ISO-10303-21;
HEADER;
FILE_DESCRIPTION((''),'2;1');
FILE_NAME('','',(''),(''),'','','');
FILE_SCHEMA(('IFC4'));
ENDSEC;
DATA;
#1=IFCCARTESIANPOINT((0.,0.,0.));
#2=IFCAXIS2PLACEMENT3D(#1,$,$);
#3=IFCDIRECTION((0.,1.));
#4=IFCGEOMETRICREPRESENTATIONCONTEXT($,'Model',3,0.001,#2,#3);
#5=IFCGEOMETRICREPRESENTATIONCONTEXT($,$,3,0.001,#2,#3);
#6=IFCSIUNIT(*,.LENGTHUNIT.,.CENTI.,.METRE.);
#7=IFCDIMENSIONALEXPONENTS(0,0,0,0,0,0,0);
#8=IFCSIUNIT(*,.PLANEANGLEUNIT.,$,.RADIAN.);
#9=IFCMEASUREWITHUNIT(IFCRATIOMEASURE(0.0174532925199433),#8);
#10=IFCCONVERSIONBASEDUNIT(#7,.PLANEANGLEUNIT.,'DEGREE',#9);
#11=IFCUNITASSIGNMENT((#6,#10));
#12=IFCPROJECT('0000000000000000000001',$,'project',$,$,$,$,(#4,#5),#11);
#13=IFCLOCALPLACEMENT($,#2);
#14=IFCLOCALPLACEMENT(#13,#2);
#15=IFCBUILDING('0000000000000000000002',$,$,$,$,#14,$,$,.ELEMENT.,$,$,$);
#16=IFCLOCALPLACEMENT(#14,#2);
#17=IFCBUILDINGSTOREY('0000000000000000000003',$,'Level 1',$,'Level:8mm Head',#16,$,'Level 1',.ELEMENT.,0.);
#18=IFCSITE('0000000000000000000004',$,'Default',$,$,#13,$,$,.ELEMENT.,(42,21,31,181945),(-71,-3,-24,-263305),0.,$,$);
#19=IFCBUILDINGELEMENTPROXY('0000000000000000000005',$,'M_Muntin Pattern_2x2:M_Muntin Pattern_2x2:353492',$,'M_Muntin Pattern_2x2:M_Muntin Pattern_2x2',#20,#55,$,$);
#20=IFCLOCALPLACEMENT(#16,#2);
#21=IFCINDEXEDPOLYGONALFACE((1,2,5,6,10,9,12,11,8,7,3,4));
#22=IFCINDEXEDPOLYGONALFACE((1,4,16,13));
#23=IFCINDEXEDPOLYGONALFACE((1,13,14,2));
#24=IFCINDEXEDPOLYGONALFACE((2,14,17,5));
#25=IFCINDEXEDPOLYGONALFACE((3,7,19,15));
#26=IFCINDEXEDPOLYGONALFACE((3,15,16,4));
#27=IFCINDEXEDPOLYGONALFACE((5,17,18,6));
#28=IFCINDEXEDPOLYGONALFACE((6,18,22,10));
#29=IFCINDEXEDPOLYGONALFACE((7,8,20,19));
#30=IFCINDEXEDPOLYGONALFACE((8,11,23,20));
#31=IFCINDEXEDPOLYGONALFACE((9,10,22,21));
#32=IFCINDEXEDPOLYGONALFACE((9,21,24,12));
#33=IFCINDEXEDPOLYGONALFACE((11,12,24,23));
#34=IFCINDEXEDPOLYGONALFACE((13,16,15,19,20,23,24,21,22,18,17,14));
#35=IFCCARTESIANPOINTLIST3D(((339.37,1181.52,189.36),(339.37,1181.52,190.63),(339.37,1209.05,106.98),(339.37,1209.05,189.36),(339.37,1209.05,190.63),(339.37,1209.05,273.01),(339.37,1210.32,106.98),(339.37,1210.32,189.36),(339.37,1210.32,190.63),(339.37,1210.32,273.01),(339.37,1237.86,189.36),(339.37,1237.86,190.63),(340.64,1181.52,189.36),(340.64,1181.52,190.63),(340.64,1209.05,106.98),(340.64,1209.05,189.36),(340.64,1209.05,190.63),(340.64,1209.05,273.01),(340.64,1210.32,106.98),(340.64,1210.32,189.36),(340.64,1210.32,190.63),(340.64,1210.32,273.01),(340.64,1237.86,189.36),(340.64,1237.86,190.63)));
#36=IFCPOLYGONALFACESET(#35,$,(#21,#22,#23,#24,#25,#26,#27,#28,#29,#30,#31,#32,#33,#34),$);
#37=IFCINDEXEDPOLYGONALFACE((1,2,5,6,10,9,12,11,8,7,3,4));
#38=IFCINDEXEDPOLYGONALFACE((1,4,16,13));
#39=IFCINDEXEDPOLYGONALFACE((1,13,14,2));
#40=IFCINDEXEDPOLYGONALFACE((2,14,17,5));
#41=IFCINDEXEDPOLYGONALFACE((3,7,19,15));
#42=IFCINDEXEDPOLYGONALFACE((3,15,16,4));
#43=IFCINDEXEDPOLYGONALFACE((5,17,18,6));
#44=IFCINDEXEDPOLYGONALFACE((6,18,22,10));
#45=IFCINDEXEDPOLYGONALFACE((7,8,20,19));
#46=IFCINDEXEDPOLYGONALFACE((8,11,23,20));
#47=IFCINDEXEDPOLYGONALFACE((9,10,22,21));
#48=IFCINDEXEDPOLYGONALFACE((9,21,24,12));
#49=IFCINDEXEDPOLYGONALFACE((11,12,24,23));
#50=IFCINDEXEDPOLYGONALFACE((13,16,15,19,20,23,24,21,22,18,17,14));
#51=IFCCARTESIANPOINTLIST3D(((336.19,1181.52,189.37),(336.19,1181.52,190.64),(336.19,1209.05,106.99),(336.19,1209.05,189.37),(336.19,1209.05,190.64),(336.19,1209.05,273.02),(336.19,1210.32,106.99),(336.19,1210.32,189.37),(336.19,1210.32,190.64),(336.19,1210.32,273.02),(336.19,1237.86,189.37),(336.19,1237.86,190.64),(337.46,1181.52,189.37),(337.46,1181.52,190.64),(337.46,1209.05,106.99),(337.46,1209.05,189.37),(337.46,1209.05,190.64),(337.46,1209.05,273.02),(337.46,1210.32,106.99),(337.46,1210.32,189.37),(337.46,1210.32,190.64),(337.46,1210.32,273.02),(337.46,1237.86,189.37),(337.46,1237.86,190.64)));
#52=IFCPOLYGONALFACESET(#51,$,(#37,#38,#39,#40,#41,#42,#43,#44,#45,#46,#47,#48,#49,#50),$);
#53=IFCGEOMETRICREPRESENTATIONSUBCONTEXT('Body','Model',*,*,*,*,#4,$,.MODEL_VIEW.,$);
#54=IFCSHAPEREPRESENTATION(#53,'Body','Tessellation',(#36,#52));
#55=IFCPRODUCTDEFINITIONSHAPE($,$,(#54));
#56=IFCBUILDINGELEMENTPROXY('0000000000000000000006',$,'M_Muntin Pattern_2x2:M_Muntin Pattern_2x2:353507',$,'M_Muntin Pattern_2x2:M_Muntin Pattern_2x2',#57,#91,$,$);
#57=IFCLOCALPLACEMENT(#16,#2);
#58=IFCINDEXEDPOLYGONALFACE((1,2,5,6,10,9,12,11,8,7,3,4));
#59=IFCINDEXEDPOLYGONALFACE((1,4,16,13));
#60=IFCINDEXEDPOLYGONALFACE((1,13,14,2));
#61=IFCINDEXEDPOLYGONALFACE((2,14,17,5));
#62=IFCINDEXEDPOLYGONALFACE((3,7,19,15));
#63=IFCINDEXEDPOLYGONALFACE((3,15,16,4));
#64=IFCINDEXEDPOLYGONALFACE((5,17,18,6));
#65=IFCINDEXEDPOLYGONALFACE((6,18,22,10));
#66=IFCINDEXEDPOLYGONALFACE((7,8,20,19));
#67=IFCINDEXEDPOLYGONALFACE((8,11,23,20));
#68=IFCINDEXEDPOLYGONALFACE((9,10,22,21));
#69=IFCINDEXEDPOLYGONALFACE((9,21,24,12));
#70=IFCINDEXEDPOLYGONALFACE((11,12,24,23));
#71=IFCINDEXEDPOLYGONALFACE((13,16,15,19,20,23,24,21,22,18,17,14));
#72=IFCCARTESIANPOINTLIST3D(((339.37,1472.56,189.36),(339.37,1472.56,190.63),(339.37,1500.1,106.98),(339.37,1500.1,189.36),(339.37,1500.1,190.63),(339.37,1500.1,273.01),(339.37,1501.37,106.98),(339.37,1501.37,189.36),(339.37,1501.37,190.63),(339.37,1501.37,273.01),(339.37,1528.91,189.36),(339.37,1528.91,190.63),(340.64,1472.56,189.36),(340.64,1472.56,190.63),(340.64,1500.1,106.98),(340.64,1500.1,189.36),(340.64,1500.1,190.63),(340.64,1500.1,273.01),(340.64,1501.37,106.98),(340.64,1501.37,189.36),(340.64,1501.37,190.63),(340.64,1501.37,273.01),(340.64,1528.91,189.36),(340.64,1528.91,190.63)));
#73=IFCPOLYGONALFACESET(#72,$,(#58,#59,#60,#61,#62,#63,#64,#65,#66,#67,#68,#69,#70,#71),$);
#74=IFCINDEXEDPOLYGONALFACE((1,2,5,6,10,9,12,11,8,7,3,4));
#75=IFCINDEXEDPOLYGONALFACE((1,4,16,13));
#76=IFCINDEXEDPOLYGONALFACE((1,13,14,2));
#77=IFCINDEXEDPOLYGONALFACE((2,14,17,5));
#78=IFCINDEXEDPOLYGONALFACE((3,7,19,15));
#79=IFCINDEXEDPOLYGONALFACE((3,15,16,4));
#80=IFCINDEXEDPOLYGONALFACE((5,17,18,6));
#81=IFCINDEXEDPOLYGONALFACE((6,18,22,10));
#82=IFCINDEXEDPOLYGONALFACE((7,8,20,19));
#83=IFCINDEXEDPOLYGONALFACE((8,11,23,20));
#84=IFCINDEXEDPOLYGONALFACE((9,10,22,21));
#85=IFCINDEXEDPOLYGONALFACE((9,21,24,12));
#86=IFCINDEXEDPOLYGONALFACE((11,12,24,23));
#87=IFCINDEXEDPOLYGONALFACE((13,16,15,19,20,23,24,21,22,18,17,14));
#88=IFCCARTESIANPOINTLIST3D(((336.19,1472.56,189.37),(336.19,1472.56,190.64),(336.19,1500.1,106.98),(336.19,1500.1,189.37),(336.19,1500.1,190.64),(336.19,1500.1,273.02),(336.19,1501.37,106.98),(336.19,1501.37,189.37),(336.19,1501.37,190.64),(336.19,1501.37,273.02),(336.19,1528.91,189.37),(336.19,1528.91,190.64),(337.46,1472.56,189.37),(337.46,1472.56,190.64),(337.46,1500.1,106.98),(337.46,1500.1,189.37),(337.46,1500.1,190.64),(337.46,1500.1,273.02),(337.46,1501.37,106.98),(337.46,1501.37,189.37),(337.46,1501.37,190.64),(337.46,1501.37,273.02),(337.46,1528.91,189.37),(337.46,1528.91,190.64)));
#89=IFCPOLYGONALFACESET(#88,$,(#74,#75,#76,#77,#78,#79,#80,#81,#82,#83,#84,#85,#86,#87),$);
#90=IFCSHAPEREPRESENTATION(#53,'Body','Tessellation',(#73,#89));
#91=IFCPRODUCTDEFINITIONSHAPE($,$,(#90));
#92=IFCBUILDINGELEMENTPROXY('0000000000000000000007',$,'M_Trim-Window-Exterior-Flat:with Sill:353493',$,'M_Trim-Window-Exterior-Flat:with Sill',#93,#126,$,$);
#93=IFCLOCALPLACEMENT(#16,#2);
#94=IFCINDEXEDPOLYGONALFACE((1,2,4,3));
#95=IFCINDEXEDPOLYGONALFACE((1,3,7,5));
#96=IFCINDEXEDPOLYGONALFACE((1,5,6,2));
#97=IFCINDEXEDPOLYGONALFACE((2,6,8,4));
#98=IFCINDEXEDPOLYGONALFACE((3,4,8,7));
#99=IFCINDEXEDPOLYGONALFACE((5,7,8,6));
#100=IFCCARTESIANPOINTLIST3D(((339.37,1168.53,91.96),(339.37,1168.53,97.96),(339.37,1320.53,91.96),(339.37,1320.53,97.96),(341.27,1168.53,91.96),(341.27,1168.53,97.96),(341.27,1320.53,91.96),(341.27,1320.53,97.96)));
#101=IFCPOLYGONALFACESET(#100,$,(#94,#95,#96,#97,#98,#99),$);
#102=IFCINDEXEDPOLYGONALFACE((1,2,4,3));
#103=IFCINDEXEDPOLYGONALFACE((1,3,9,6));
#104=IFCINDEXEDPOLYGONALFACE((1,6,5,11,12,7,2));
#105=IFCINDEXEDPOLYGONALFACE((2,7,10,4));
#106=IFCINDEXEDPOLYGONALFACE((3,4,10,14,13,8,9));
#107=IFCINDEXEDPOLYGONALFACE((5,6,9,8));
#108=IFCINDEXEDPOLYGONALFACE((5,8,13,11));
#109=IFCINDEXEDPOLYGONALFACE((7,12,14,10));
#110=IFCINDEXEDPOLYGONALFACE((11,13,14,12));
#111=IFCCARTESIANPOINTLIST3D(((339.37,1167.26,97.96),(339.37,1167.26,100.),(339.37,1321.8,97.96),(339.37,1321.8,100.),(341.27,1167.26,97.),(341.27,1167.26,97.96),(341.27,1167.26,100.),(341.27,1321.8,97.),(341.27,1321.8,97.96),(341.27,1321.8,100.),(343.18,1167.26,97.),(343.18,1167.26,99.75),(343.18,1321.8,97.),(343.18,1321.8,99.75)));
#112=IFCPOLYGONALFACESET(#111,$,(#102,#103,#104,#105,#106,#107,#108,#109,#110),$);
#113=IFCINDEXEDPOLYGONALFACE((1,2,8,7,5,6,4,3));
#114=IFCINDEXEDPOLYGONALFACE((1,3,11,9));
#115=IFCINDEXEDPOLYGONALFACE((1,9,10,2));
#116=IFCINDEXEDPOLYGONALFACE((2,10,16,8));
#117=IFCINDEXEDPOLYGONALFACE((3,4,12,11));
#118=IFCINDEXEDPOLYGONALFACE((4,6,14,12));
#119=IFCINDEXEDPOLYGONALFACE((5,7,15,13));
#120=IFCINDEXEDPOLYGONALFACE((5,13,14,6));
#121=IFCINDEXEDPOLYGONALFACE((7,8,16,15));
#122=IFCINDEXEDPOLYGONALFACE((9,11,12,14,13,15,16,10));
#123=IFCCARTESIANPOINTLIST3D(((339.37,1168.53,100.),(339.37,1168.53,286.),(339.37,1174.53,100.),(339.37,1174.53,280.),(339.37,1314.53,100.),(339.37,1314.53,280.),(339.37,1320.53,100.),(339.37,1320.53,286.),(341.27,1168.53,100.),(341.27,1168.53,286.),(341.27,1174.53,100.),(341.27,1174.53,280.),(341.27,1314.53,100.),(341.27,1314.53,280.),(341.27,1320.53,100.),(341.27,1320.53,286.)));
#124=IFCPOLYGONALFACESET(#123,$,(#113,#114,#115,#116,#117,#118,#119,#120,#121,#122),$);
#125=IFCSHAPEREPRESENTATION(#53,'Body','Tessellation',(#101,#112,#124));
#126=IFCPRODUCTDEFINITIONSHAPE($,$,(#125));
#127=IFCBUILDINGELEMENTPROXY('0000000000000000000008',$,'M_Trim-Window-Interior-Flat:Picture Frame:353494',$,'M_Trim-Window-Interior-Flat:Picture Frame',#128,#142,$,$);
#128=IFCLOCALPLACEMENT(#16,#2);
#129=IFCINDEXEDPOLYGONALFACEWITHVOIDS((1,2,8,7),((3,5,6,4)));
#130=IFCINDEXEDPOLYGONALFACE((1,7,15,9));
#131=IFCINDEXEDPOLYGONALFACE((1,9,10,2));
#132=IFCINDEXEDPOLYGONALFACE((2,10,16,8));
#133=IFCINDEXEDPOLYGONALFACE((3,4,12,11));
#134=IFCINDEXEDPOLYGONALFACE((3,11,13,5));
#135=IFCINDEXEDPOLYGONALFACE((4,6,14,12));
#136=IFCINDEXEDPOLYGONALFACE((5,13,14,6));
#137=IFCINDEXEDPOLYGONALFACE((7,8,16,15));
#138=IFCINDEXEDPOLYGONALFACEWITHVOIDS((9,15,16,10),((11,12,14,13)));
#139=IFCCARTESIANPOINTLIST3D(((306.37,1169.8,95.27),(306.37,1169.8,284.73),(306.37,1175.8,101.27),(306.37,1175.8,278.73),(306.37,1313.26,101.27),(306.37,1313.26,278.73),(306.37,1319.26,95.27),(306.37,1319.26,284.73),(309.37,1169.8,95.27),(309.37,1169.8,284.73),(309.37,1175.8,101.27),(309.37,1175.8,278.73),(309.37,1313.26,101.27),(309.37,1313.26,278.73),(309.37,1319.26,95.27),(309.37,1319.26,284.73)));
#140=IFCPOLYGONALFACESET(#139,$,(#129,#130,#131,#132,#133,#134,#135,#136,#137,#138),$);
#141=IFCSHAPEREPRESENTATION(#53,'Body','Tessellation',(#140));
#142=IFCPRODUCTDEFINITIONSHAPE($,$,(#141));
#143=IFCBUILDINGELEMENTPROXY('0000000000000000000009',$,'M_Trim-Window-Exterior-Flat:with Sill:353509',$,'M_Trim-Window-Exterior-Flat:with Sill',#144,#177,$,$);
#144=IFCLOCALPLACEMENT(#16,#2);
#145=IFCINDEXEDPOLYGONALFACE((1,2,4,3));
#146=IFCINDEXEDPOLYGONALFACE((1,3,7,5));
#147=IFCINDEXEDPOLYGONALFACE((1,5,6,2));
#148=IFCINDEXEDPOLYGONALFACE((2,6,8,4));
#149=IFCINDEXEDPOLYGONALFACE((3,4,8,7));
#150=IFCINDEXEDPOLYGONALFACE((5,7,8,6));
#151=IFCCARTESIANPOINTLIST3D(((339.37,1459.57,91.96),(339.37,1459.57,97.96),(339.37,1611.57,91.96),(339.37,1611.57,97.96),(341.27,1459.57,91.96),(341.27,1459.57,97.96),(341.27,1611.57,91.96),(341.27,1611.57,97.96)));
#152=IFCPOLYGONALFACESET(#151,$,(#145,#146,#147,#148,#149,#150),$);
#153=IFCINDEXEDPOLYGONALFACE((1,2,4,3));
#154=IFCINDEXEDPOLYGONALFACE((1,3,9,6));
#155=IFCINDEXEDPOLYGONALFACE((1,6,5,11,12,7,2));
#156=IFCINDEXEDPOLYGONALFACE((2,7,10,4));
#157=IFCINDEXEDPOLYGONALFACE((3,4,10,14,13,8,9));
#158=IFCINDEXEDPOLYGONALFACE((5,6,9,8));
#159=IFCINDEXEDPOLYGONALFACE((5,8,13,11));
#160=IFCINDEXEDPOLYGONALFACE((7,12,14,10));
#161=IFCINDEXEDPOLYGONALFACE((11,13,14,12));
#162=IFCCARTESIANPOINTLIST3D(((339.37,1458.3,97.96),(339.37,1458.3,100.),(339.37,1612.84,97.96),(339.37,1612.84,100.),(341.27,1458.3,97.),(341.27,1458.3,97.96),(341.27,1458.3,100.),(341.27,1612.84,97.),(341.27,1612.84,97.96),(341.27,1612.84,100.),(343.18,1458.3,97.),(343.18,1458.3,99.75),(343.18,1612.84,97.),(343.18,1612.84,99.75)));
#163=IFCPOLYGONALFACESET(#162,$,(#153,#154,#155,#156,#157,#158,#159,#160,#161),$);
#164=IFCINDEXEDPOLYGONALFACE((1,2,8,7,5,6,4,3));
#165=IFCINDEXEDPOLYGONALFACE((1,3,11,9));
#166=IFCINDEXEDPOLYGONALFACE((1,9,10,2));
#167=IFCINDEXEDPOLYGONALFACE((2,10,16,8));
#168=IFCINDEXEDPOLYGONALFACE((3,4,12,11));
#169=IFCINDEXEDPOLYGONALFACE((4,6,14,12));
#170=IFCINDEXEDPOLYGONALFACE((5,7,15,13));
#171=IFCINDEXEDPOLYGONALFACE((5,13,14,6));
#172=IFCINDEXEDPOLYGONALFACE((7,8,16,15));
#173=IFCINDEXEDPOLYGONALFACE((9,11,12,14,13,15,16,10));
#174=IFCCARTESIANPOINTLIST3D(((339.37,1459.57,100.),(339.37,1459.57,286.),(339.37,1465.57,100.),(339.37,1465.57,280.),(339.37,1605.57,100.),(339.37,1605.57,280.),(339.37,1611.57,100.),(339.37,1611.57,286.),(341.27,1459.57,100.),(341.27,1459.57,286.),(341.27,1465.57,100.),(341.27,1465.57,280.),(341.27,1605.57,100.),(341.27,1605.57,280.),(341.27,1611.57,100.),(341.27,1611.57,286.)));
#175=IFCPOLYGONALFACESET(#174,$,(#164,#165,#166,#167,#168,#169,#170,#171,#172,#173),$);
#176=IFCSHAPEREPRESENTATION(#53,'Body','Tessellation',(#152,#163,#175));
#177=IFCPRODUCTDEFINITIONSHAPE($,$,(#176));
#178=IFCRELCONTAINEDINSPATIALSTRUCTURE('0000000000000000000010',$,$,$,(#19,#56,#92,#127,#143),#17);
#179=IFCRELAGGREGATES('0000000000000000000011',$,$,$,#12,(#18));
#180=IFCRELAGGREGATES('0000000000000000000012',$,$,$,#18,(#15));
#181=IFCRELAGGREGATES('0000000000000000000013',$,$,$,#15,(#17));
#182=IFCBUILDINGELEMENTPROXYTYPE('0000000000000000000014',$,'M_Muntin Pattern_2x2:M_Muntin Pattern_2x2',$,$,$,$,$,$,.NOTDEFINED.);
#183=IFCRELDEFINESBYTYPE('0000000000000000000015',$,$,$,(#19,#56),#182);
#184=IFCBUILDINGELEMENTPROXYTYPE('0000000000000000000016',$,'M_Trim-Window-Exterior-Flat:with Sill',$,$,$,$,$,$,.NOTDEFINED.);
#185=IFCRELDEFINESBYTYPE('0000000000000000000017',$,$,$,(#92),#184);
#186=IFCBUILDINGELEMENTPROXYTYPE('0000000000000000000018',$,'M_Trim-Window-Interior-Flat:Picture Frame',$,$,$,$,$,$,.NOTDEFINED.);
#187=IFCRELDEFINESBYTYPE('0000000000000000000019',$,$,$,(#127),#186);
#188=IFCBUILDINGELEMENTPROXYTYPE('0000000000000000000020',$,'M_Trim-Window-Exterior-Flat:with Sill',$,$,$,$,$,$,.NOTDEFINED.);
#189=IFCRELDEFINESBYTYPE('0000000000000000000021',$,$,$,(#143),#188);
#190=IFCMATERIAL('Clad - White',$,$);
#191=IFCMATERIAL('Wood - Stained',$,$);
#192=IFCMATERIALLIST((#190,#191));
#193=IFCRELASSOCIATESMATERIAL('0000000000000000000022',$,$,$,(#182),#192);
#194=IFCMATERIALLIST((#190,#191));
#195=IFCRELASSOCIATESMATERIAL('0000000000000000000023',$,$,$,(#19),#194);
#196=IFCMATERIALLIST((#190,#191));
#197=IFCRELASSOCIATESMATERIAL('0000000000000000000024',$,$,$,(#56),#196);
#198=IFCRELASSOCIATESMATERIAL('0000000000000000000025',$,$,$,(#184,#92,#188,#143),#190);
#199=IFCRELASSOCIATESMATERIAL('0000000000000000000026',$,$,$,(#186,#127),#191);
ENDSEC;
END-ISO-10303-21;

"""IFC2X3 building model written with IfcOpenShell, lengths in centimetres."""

from ifc_helpers import new_model, entity, si_unit, converted_unit, direction, frame, frame_2d, origin, place, context, subcontext, project, spatial, polyline, rectangle, outline, extrude, source, transform, mapped, material, material_list, type_object, type_shapes, element, save


model = new_model("IFC2X3")

# Units and contexts
model_context = context("Model", 3, precision=0.001, world=origin(), true_north=direction((0.0, 1.0)))
context_of_model = context(None, 3, precision=0.001, world=origin(), true_north=direction((0.0, 1.0)))
body_context = subcontext(model_context, "Body", "Model", "MODEL_VIEW")
ifc_project = project(units=[si_unit("LENGTHUNIT", "METRE", prefix="CENTI"), converted_unit("PLANEANGLEUNIT", "DEGREE", entity("IfcRatioMeasure", 0.0174532925199433), si_unit("PLANEANGLEUNIT", "RADIAN"), dimensions=[0, 0, 0, 0, 0, 0, 0])], contexts=[model_context, context_of_model])

# Site, building, storey
site_placement = place(None, origin())
site = spatial("IfcSite", under=ifc_project, at=site_placement, Name="Default", CompositionType="ELEMENT", RefLatitude=(42, 21, 31, 181945), RefLongitude=(-71, -3, -24, -263305), RefElevation=0.0)
building_placement = place(site_placement, origin())
building = spatial("IfcBuilding", under=site, at=building_placement, CompositionType="ELEMENT")
storey_placement = place(building_placement, origin())
storey = spatial("IfcBuildingStorey", under=building, at=storey_placement, Name="Level 1", ObjectType="Level:8mm Head", LongName="Level 1", CompositionType="ELEMENT", Elevation=0.0)

# Building element proxies
ifc_material_1 = material(Name="Clad - White")
ifc_material_2 = material(Name="Wood - Stained")
ifc_material_list_1 = material_list([ifc_material_1, ifc_material_2])
ifc_material_list_2 = material_list([ifc_material_1, ifc_material_2])
building_element_proxy_type_1 = type_object("IfcBuildingElementProxyType", Name="M_Muntin Pattern_2x2:M_Muntin Pattern_2x2", PredefinedType="NOTDEFINED", material=ifc_material_list_2)
shared_shape_1 = source(origin(), body_context, "Body", "SweptSolid", [
    extrude(outline(polyline([(0.64, -0.64), (83.01, -0.64), (83.01, 0.63), (0.64, 0.63), (0.64, 28.17), (-0.63, 28.17), (-0.63, 0.63), (-83.02, 0.63), (-83.02, -0.64), (-0.63, -0.64), (-0.63, -28.17), (0.64, -28.17), (0.64, -0.64)])), frame((0.0, -2.22, 83.01), z_axis=(0.0, 1.0, 0.0), x_axis=(0.0, 0.0, 1.0)), (0.0, 0.0, 1.0), 1.27),
    extrude(outline(polyline([(0.64, -0.64), (83.02, -0.64), (83.02, 0.63), (0.64, 0.63), (0.64, 28.17), (-0.63, 28.17), (-0.63, 0.63), (-83.02, 0.63), (-83.02, -0.64), (-0.63, -0.64), (-0.63, -28.17), (0.64, -28.17), (0.64, -0.64)])), frame((0.0, 0.95, 83.02), z_axis=(0.0, 1.0, 0.0), x_axis=(0.0, 0.0, 1.0)), (0.0, 0.0, 1.0), 1.27),
])
type_shapes(building_element_proxy_type_1, [shared_shape_1])
proxy_1_placement = place(storey_placement, frame((338.41, 1209.69, 106.99), z_axis=(0.0, 0.0, 1.0), x_axis=(0.0, 1.0, 0.0)))
element("IfcBuildingElementProxy", 1, at=proxy_1_placement, inside=storey, type_object=building_element_proxy_type_1, material=ifc_material_list_1, Name="M_Muntin Pattern_2x2:M_Muntin Pattern_2x2:353492", ObjectType="M_Muntin Pattern_2x2:M_Muntin Pattern_2x2", context=body_context, shape_type="MappedRepresentation", body=[
    mapped(shared_shape_1, transform((0.0, 0.0, 0.0), scale=1.0)),
])
ifc_material_list_3 = material_list([ifc_material_1, ifc_material_2])
proxy_2_placement = place(storey_placement, frame((338.41, 1500.73, 106.98), z_axis=(0.0, 0.0, 1.0), x_axis=(0.0, 1.0, 0.0)))
element("IfcBuildingElementProxy", 2, at=proxy_2_placement, inside=storey, type_object=building_element_proxy_type_1, material=ifc_material_list_3, Name="M_Muntin Pattern_2x2:M_Muntin Pattern_2x2:353507", ObjectType="M_Muntin Pattern_2x2:M_Muntin Pattern_2x2", context=body_context, shape_type="MappedRepresentation", body=[
    mapped(shared_shape_1, transform((0.0, 0.0, 0.0), scale=1.0)),
])
building_element_proxy_type_2 = type_object("IfcBuildingElementProxyType", Name="M_Trim-Window-Exterior-Flat:with Sill", PredefinedType="NOTDEFINED", material=ifc_material_1)
shared_shape_2 = source(origin(), body_context, "Body", "SweptSolid", [
    extrude(rectangle(XDim=152.0, YDim=6.0, at=frame_2d((0.0, 0.0), x_axis=(1.0, 0.0))), frame((0.0, -185.04, 0.0), z_axis=(0.0, 0.0, 1.0), x_axis=(-1.0, 0.0, 0.0)), (0.0, 0.0, 1.0), 1.91),
    extrude(outline(polyline([(-1.9, -1.52), (0.0, -1.52), (0.0, -0.57), (1.9, -0.57), (1.9, 1.48), (0.0, 1.48), (-1.9, 1.23), (-1.9, -1.52)])), frame((-77.27, -181.48, 1.9), z_axis=(1.0, 0.0, 0.0), x_axis=(0.0, 0.0, -1.0)), (0.0, 0.0, 1.0), 154.54),
    extrude(outline(polyline([(-94.5, -76.0), (91.5, -76.0), (91.5, -70.0), (-88.5, -70.0), (-88.5, 70.0), (91.5, 70.0), (91.5, 76.0), (-94.5, 76.0), (-94.5, -76.0)])), frame((0.0, -88.5, 0.0), z_axis=(0.0, 0.0, 1.0), x_axis=(0.0, -1.0, 0.0)), (0.0, 0.0, 1.0), 1.91),
])
type_shapes(building_element_proxy_type_2, [shared_shape_2])
proxy_3_placement = place(storey_placement, frame((339.37, 1244.53, 280.0), z_axis=(1.0, 0.0, 0.0), x_axis=(0.0, 1.0, 0.0)))
element("IfcBuildingElementProxy", 3, at=proxy_3_placement, inside=storey, type_object=building_element_proxy_type_2, material=ifc_material_1, Name="M_Trim-Window-Exterior-Flat:with Sill:353493", ObjectType="M_Trim-Window-Exterior-Flat:with Sill", context=body_context, shape_type="MappedRepresentation", body=[
    mapped(shared_shape_2, transform((0.0, 0.0, 0.0), scale=1.0)),
])
building_element_proxy_type_3 = type_object("IfcBuildingElementProxyType", Name="M_Trim-Window-Interior-Flat:Picture Frame", PredefinedType="NOTDEFINED", material=ifc_material_2)
shared_shape_3 = source(origin(), body_context, "Body", "SweptSolid", [
    extrude(outline(polyline([(-74.73, -94.73), (74.73, -94.73), (74.73, 94.73), (-74.73, 94.73), (-74.73, -94.73)]), holes=[polyline([(-68.73, -88.73), (-68.73, 88.73), (68.73, 88.73), (68.73, -88.73), (-68.73, -88.73)])]), frame((0.0, -90.0, 0.0), z_axis=(0.0, 0.0, 1.0), x_axis=(-1.0, 0.0, 0.0)), (0.0, 0.0, 1.0), 3.0),
])
type_shapes(building_element_proxy_type_3, [shared_shape_3])
proxy_4_placement = place(storey_placement, frame((309.37, 1244.53, 280.0), z_axis=(-1.0, 0.0, 0.0), x_axis=(0.0, -1.0, 0.0)))
element("IfcBuildingElementProxy", 4, at=proxy_4_placement, inside=storey, type_object=building_element_proxy_type_3, material=ifc_material_2, Name="M_Trim-Window-Interior-Flat:Picture Frame:353494", ObjectType="M_Trim-Window-Interior-Flat:Picture Frame", context=body_context, shape_type="MappedRepresentation", body=[
    mapped(shared_shape_3, transform((0.0, 0.0, 0.0), scale=1.0)),
])
building_element_proxy_type_4 = type_object("IfcBuildingElementProxyType", Name="M_Trim-Window-Exterior-Flat:with Sill", PredefinedType="NOTDEFINED", material=ifc_material_1)
shared_shape_4 = source(origin(), body_context, "Body", "SweptSolid", [
    extrude(rectangle(XDim=6.0, YDim=152.0, at=frame_2d((0.0, 0.0), x_axis=(1.0, 0.0))), frame((0.0, 185.04, 0.0), z_axis=(0.0, 0.0, 1.0), x_axis=(0.0, 1.0, 0.0)), (0.0, 0.0, 1.0), 1.91),
    extrude(outline(polyline([(-1.52, -1.9), (1.23, -1.9), (1.48, 0.0), (1.48, 1.9), (-0.57, 1.9), (-0.57, 0.0), (-1.52, 0.0), (-1.52, -1.9)])), frame((-77.27, 181.48, 1.9), z_axis=(1.0, 0.0, 0.0), x_axis=(0.0, -1.0, 0.0)), (0.0, 0.0, 1.0), 154.54),
    extrude(outline(polyline([(-76.0, -94.5), (76.0, -94.5), (76.0, 91.5), (70.0, 91.5), (70.0, -88.5), (-70.0, -88.5), (-70.0, 91.5), (-76.0, 91.5), (-76.0, -94.5)])), frame((0.0, 88.5, 0.0)), (0.0, 0.0, 1.0), 1.91),
])
type_shapes(building_element_proxy_type_4, [shared_shape_4])
proxy_5_placement = place(storey_placement, frame((339.37, 1535.57, 280.0), z_axis=(1.0, 0.0, 0.0), x_axis=(0.0, -1.0, 0.0)))
element("IfcBuildingElementProxy", 5, at=proxy_5_placement, inside=storey, type_object=building_element_proxy_type_4, material=ifc_material_1, Name="M_Trim-Window-Exterior-Flat:with Sill:353509", ObjectType="M_Trim-Window-Exterior-Flat:with Sill", context=body_context, shape_type="MappedRepresentation", body=[
    mapped(shared_shape_4, transform((0.0, 0.0, 0.0), scale=1.0)),
])

save(model, "model.ifc")
